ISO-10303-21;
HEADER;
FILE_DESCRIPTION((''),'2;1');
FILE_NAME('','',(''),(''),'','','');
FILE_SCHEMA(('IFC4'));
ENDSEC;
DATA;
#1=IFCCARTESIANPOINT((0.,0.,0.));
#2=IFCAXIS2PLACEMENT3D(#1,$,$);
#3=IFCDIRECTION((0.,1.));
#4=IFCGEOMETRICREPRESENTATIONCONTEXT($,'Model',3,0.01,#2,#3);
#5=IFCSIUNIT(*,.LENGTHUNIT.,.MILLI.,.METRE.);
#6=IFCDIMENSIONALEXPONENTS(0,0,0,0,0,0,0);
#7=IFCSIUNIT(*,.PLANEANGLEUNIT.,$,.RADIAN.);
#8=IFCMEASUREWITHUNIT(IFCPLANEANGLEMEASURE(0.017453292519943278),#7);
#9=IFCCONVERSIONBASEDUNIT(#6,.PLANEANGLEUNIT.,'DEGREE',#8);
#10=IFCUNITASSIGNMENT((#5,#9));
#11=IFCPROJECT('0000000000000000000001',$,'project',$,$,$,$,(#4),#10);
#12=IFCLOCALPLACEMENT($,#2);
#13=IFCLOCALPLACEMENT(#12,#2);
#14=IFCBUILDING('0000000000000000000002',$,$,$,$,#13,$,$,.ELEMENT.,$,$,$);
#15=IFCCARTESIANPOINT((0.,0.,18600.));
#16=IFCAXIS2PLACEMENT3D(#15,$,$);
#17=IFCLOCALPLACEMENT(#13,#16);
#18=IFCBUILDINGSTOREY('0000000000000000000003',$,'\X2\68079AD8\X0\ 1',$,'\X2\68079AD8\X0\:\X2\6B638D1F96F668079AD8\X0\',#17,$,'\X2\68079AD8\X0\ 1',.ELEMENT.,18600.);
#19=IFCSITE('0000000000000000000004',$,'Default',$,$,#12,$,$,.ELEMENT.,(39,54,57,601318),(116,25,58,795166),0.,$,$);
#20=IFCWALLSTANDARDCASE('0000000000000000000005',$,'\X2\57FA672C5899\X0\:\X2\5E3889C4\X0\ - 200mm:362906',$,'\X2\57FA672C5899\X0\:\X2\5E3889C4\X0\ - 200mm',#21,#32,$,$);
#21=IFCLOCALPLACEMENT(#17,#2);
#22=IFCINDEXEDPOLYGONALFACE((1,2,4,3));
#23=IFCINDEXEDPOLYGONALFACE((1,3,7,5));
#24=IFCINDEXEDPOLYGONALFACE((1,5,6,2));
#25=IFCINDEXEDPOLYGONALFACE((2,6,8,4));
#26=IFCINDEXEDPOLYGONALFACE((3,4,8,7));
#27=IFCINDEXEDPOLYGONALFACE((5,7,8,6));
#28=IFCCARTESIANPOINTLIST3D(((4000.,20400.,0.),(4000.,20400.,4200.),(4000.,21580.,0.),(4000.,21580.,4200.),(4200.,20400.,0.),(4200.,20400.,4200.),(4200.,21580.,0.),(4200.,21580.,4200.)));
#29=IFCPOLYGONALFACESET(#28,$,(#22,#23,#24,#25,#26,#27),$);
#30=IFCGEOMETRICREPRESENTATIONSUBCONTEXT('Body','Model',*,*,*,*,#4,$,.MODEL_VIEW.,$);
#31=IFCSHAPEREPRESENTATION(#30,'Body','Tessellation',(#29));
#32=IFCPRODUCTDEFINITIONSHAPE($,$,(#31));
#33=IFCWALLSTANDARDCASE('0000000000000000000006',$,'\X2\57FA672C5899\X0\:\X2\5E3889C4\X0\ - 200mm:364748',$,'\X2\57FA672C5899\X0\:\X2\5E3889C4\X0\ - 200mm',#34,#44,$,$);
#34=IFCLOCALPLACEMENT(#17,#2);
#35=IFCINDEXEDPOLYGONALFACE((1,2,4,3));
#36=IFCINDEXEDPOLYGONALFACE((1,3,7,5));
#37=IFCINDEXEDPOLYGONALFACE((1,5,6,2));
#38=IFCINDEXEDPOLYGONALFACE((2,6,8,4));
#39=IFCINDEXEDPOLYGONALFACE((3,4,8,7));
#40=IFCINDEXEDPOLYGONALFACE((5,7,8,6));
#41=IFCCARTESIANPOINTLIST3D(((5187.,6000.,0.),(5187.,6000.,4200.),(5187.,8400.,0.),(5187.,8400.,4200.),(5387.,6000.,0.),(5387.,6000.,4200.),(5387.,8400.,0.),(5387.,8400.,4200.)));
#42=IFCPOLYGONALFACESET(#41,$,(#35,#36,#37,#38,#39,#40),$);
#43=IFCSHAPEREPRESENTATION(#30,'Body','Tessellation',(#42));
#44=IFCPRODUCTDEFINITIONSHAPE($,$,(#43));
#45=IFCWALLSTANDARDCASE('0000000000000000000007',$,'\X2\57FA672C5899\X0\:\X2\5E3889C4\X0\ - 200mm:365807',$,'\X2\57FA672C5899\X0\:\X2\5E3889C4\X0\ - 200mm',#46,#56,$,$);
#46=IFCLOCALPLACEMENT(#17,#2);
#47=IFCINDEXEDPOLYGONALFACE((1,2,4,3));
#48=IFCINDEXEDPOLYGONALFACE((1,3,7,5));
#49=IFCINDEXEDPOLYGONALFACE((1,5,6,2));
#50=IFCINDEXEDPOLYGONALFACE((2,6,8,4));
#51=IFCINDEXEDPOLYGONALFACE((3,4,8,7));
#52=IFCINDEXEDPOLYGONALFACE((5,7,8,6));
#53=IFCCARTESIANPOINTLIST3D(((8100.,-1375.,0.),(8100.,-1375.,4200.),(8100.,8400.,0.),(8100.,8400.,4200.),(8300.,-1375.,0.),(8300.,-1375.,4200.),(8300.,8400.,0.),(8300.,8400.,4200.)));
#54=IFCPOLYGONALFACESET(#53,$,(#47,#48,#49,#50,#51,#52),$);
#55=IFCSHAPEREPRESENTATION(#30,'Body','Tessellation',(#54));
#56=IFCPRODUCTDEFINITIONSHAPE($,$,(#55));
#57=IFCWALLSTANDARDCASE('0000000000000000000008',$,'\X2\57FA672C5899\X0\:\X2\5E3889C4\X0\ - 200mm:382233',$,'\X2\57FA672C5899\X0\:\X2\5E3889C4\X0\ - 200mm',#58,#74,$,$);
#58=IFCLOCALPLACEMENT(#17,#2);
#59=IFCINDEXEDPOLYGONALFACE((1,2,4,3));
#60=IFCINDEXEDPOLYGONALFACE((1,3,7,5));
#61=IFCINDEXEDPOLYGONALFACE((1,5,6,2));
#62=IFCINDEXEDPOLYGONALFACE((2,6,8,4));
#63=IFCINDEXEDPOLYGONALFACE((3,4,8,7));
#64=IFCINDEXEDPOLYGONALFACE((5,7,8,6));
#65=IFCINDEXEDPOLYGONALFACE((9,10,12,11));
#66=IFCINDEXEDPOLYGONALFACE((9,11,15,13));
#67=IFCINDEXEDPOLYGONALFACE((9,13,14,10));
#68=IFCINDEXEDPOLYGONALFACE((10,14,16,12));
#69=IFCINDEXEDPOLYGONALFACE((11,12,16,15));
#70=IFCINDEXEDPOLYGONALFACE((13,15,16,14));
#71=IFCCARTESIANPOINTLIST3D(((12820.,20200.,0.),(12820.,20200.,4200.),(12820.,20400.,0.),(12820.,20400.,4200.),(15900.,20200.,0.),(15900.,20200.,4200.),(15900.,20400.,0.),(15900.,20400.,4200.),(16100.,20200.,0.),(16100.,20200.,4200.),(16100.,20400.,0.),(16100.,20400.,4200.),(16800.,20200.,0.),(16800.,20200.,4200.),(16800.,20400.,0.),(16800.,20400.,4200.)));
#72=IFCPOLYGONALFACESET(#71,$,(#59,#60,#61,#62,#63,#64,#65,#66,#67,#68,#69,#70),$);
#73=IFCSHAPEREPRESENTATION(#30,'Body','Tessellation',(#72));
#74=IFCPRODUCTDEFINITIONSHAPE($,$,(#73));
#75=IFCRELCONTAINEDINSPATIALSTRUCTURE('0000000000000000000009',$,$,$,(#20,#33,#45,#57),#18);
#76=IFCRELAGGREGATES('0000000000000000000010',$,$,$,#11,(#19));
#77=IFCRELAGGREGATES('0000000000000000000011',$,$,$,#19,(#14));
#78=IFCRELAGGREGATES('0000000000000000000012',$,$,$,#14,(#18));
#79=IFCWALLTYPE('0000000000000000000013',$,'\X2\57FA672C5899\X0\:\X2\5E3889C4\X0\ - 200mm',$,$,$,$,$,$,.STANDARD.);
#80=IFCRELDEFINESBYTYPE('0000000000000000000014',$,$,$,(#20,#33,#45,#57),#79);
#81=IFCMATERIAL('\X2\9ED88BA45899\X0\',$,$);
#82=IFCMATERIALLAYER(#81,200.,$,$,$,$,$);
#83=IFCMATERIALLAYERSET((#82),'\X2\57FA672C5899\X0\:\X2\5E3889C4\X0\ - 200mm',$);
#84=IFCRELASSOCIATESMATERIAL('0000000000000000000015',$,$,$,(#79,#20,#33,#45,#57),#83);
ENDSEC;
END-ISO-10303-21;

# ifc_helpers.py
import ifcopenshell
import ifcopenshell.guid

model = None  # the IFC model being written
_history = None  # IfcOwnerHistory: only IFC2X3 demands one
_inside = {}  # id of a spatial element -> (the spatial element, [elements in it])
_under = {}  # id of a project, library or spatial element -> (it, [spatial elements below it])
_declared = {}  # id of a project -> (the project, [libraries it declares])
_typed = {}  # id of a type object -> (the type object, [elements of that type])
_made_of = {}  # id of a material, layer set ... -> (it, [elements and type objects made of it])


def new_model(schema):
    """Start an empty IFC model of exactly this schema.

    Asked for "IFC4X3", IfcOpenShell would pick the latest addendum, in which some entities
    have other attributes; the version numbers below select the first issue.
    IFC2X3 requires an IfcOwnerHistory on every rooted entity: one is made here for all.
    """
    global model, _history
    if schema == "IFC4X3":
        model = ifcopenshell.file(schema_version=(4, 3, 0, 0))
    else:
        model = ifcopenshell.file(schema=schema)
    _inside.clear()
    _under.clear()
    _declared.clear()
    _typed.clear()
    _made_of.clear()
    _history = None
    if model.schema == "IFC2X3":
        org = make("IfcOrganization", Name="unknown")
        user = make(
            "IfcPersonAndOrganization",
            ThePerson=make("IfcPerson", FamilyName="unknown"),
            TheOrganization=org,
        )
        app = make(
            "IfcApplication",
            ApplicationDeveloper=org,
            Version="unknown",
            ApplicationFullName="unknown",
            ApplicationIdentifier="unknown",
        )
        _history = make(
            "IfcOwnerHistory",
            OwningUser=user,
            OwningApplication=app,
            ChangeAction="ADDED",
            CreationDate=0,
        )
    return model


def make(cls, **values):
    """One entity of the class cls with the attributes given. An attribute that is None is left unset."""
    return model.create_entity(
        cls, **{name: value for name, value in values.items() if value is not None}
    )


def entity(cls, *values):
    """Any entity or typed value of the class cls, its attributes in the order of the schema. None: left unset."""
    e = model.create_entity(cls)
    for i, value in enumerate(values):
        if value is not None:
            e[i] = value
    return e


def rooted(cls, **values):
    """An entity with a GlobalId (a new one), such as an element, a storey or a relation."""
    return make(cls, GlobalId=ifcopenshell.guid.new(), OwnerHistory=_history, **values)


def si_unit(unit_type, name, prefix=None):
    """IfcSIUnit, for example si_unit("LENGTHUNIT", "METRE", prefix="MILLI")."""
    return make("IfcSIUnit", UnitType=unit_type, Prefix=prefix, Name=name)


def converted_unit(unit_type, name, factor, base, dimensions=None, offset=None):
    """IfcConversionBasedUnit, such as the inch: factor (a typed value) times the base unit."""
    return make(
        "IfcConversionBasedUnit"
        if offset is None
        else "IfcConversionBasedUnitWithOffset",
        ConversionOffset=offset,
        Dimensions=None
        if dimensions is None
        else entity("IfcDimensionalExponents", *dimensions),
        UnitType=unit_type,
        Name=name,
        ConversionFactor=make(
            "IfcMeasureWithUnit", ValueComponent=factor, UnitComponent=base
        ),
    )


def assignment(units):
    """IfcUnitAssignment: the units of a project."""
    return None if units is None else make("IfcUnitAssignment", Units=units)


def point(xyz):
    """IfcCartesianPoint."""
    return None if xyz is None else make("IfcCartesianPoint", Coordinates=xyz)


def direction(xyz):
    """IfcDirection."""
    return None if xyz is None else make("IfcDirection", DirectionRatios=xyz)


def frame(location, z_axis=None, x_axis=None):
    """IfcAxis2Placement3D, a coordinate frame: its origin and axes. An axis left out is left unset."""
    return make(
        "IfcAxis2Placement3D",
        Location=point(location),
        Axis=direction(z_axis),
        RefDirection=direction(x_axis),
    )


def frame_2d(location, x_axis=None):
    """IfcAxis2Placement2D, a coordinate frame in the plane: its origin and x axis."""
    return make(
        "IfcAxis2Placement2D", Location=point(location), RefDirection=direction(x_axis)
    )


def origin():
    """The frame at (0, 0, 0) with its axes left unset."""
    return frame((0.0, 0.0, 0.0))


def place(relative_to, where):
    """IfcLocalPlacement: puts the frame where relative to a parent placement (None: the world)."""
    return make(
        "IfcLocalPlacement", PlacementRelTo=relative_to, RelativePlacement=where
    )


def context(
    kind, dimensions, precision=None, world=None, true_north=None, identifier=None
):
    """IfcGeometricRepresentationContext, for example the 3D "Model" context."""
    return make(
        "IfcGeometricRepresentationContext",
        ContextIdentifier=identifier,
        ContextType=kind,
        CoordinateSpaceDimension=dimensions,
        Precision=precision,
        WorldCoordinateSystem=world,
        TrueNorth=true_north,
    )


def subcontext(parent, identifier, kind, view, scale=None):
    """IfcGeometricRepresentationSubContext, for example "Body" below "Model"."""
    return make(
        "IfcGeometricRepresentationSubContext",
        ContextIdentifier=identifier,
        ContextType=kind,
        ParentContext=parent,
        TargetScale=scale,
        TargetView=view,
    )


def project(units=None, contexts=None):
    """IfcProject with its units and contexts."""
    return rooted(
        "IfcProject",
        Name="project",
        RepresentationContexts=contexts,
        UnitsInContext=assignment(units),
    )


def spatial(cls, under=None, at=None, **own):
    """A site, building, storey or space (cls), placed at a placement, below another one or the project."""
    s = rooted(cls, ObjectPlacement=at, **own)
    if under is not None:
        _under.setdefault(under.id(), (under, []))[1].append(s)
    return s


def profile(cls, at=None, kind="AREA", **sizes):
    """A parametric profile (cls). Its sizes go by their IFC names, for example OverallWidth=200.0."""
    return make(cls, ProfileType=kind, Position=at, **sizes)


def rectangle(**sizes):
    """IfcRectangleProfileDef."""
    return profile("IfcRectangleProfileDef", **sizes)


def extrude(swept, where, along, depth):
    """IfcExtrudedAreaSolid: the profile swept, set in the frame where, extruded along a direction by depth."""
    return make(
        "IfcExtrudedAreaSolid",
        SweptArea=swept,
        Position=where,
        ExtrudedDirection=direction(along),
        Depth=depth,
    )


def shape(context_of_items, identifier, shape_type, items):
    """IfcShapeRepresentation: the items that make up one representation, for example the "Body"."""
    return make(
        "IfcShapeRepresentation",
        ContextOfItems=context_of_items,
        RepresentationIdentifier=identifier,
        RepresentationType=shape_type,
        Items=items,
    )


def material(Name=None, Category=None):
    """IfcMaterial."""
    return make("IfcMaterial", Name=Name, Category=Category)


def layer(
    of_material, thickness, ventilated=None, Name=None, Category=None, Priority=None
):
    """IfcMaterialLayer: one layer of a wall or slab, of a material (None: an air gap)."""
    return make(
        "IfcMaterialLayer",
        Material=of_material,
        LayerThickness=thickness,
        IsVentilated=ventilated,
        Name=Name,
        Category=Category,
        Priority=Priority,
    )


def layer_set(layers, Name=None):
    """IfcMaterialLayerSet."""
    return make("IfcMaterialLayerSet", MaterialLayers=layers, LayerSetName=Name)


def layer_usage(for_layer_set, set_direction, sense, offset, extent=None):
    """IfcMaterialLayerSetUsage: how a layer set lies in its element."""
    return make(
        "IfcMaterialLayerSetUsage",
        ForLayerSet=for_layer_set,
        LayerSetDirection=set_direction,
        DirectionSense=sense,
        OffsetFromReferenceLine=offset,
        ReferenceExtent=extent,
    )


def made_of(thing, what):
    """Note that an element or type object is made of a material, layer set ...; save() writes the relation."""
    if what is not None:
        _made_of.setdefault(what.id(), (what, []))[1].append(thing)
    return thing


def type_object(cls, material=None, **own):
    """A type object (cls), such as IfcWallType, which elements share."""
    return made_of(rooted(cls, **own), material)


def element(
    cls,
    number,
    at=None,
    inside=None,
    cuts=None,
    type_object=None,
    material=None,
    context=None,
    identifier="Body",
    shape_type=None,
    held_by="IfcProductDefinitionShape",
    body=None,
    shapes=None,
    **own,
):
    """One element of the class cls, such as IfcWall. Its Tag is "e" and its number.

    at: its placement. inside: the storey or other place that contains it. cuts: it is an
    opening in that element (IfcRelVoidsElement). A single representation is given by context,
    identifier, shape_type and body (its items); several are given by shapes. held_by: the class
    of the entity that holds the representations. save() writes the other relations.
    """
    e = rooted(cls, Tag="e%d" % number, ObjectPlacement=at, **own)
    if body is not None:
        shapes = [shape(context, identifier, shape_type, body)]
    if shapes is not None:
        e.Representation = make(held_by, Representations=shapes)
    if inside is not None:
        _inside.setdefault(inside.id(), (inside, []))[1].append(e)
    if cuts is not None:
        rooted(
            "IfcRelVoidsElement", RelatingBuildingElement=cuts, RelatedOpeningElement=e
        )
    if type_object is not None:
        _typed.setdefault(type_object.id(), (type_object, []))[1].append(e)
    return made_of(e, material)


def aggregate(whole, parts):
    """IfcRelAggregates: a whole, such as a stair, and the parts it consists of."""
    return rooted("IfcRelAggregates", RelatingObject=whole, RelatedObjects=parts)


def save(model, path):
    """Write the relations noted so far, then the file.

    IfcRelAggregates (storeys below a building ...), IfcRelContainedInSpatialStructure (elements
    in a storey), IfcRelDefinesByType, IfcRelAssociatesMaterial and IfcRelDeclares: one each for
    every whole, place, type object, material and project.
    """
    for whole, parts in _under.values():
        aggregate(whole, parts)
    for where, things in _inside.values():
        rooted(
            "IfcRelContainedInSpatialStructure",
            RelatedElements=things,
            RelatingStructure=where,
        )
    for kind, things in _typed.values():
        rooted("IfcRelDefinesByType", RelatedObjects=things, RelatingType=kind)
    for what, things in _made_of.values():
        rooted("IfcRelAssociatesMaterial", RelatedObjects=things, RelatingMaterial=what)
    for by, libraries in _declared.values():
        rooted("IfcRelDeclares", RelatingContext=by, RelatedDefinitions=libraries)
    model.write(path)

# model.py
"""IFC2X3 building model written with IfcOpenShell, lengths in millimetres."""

from ifc_helpers import new_model, entity, si_unit, converted_unit, direction, frame, frame_2d, origin, place, context, subcontext, project, spatial, rectangle, extrude, material, layer, layer_set, layer_usage, type_object, element, save


model = new_model("IFC2X3")

# Units and contexts
model_context = context("Model", 3, precision=0.01, world=origin(), true_north=direction((0.0, 1.0)))
body_context = subcontext(model_context, "Body", "Model", "MODEL_VIEW")
ifc_project = project(units=[si_unit("LENGTHUNIT", "METRE", prefix="MILLI"), converted_unit("PLANEANGLEUNIT", "DEGREE", entity("IfcPlaneAngleMeasure", 0.017453292519943278), si_unit("PLANEANGLEUNIT", "RADIAN"), dimensions=[0, 0, 0, 0, 0, 0, 0])], contexts=[model_context])

# Site, building, storey
site_placement = place(None, origin())
site = spatial("IfcSite", under=ifc_project, at=site_placement, Name="Default", CompositionType="ELEMENT", RefLatitude=(39, 54, 57, 601318), RefLongitude=(116, 25, 58, 795166), RefElevation=0.0)
building_placement = place(site_placement, origin())
building = spatial("IfcBuilding", under=site, at=building_placement, CompositionType="ELEMENT")
storey_placement = place(building_placement, frame((0.0, 0.0, 18600.0)))
storey = spatial("IfcBuildingStorey", under=building, at=storey_placement, Name="标高 1", ObjectType="标高:正负零标高", LongName="标高 1", CompositionType="ELEMENT", Elevation=18600.0)

# Shared definitions
ifc_material_1 = material(Name="默认墙")
ifc_layer = layer(ifc_material_1, 200.0)
ifc_layer_set = layer_set([ifc_layer], Name="基本墙:常规 - 200mm")
wall_type = type_object("IfcWallType", Name="基本墙:常规 - 200mm", PredefinedType="STANDARD", material=ifc_layer_set)

# Walls
ifc_layer_usage_1 = layer_usage(ifc_layer_set, "AXIS2", "NEGATIVE", 100.0)
wall_1_placement = place(storey_placement, frame((4100.0, 20400.0, 0.0), z_axis=(0.0, 0.0, 1.0), x_axis=(0.0, 1.0, 0.0)))
element("IfcWallStandardCase", 1, at=wall_1_placement, inside=storey, type_object=wall_type, material=ifc_layer_usage_1, Name="基本墙:常规 - 200mm:362906", ObjectType="基本墙:常规 - 200mm", context=body_context, shape_type="SweptSolid", body=[
    extrude(rectangle(XDim=1180.0, YDim=200.0, at=frame_2d((590.0, 0.0), x_axis=(-1.0, 0.0))), origin(), (0.0, 0.0, 1.0), 4200.0),
])
ifc_layer_usage_2 = layer_usage(ifc_layer_set, "AXIS2", "NEGATIVE", 100.0)
wall_2_placement = place(storey_placement, frame((5287.0, 8400.0, 0.0), z_axis=(0.0, 0.0, 1.0), x_axis=(0.0, -1.0, 0.0)))
element("IfcWallStandardCase", 2, at=wall_2_placement, inside=storey, type_object=wall_type, material=ifc_layer_usage_2, Name="基本墙:常规 - 200mm:364748", ObjectType="基本墙:常规 - 200mm", context=body_context, shape_type="SweptSolid", body=[
    extrude(rectangle(XDim=2400.0, YDim=200.0, at=frame_2d((1200.0, 0.0), x_axis=(-1.0, 0.0))), origin(), (0.0, 0.0, 1.0), 4200.0),
])
ifc_layer_usage_3 = layer_usage(ifc_layer_set, "AXIS2", "NEGATIVE", 100.0)
wall_3_placement = place(storey_placement, frame((8200.0, 8400.0, 0.0), z_axis=(0.0, 0.0, 1.0), x_axis=(0.0, -1.0, 0.0)))
element("IfcWallStandardCase", 3, at=wall_3_placement, inside=storey, type_object=wall_type, material=ifc_layer_usage_3, Name="基本墙:常规 - 200mm:365807", ObjectType="基本墙:常规 - 200mm", context=body_context, shape_type="SweptSolid", body=[
    extrude(rectangle(XDim=9775.0, YDim=200.0, at=frame_2d((4887.5, 0.0), x_axis=(-1.0, 0.0))), origin(), (0.0, 0.0, 1.0), 4200.0),
])

# Wall, opening
ifc_layer_usage_4 = layer_usage(ifc_layer_set, "AXIS2", "NEGATIVE", 100.0)
wall_4_placement = place(storey_placement, frame((12820.0, 20300.0, 0.0)))
wall_4 = element("IfcWallStandardCase", 4, at=wall_4_placement, inside=storey, type_object=wall_type, material=ifc_layer_usage_4, Name="基本墙:常规 - 200mm:382233", ObjectType="基本墙:常规 - 200mm", context=body_context, shape_type="SweptSolid", body=[
    extrude(rectangle(XDim=3980.0, YDim=200.0, at=frame_2d((1990.0, 0.0), x_axis=(-1.0, 0.0))), origin(), (0.0, 0.0, 1.0), 4200.0),
])
opening_1_placement = place(storey_placement, frame((12820.0, 20300.0, 0.0)))
element("IfcOpeningElement", 5, at=opening_1_placement, cuts=wall_4, ObjectType="Opening", context=body_context, shape_type="SweptSolid", body=[
    extrude(rectangle(XDim=4200.0, YDim=200.0, at=frame_2d((0.0, 0.0), x_axis=(1.0, 0.0))), frame((3080.0, 0.0, 2100.0), z_axis=(1.0, 0.0, 0.0), x_axis=(0.0, 0.0, -1.0)), (0.0, 0.0, 1.0), 200.0),
])

save(model, "model.ifc")
